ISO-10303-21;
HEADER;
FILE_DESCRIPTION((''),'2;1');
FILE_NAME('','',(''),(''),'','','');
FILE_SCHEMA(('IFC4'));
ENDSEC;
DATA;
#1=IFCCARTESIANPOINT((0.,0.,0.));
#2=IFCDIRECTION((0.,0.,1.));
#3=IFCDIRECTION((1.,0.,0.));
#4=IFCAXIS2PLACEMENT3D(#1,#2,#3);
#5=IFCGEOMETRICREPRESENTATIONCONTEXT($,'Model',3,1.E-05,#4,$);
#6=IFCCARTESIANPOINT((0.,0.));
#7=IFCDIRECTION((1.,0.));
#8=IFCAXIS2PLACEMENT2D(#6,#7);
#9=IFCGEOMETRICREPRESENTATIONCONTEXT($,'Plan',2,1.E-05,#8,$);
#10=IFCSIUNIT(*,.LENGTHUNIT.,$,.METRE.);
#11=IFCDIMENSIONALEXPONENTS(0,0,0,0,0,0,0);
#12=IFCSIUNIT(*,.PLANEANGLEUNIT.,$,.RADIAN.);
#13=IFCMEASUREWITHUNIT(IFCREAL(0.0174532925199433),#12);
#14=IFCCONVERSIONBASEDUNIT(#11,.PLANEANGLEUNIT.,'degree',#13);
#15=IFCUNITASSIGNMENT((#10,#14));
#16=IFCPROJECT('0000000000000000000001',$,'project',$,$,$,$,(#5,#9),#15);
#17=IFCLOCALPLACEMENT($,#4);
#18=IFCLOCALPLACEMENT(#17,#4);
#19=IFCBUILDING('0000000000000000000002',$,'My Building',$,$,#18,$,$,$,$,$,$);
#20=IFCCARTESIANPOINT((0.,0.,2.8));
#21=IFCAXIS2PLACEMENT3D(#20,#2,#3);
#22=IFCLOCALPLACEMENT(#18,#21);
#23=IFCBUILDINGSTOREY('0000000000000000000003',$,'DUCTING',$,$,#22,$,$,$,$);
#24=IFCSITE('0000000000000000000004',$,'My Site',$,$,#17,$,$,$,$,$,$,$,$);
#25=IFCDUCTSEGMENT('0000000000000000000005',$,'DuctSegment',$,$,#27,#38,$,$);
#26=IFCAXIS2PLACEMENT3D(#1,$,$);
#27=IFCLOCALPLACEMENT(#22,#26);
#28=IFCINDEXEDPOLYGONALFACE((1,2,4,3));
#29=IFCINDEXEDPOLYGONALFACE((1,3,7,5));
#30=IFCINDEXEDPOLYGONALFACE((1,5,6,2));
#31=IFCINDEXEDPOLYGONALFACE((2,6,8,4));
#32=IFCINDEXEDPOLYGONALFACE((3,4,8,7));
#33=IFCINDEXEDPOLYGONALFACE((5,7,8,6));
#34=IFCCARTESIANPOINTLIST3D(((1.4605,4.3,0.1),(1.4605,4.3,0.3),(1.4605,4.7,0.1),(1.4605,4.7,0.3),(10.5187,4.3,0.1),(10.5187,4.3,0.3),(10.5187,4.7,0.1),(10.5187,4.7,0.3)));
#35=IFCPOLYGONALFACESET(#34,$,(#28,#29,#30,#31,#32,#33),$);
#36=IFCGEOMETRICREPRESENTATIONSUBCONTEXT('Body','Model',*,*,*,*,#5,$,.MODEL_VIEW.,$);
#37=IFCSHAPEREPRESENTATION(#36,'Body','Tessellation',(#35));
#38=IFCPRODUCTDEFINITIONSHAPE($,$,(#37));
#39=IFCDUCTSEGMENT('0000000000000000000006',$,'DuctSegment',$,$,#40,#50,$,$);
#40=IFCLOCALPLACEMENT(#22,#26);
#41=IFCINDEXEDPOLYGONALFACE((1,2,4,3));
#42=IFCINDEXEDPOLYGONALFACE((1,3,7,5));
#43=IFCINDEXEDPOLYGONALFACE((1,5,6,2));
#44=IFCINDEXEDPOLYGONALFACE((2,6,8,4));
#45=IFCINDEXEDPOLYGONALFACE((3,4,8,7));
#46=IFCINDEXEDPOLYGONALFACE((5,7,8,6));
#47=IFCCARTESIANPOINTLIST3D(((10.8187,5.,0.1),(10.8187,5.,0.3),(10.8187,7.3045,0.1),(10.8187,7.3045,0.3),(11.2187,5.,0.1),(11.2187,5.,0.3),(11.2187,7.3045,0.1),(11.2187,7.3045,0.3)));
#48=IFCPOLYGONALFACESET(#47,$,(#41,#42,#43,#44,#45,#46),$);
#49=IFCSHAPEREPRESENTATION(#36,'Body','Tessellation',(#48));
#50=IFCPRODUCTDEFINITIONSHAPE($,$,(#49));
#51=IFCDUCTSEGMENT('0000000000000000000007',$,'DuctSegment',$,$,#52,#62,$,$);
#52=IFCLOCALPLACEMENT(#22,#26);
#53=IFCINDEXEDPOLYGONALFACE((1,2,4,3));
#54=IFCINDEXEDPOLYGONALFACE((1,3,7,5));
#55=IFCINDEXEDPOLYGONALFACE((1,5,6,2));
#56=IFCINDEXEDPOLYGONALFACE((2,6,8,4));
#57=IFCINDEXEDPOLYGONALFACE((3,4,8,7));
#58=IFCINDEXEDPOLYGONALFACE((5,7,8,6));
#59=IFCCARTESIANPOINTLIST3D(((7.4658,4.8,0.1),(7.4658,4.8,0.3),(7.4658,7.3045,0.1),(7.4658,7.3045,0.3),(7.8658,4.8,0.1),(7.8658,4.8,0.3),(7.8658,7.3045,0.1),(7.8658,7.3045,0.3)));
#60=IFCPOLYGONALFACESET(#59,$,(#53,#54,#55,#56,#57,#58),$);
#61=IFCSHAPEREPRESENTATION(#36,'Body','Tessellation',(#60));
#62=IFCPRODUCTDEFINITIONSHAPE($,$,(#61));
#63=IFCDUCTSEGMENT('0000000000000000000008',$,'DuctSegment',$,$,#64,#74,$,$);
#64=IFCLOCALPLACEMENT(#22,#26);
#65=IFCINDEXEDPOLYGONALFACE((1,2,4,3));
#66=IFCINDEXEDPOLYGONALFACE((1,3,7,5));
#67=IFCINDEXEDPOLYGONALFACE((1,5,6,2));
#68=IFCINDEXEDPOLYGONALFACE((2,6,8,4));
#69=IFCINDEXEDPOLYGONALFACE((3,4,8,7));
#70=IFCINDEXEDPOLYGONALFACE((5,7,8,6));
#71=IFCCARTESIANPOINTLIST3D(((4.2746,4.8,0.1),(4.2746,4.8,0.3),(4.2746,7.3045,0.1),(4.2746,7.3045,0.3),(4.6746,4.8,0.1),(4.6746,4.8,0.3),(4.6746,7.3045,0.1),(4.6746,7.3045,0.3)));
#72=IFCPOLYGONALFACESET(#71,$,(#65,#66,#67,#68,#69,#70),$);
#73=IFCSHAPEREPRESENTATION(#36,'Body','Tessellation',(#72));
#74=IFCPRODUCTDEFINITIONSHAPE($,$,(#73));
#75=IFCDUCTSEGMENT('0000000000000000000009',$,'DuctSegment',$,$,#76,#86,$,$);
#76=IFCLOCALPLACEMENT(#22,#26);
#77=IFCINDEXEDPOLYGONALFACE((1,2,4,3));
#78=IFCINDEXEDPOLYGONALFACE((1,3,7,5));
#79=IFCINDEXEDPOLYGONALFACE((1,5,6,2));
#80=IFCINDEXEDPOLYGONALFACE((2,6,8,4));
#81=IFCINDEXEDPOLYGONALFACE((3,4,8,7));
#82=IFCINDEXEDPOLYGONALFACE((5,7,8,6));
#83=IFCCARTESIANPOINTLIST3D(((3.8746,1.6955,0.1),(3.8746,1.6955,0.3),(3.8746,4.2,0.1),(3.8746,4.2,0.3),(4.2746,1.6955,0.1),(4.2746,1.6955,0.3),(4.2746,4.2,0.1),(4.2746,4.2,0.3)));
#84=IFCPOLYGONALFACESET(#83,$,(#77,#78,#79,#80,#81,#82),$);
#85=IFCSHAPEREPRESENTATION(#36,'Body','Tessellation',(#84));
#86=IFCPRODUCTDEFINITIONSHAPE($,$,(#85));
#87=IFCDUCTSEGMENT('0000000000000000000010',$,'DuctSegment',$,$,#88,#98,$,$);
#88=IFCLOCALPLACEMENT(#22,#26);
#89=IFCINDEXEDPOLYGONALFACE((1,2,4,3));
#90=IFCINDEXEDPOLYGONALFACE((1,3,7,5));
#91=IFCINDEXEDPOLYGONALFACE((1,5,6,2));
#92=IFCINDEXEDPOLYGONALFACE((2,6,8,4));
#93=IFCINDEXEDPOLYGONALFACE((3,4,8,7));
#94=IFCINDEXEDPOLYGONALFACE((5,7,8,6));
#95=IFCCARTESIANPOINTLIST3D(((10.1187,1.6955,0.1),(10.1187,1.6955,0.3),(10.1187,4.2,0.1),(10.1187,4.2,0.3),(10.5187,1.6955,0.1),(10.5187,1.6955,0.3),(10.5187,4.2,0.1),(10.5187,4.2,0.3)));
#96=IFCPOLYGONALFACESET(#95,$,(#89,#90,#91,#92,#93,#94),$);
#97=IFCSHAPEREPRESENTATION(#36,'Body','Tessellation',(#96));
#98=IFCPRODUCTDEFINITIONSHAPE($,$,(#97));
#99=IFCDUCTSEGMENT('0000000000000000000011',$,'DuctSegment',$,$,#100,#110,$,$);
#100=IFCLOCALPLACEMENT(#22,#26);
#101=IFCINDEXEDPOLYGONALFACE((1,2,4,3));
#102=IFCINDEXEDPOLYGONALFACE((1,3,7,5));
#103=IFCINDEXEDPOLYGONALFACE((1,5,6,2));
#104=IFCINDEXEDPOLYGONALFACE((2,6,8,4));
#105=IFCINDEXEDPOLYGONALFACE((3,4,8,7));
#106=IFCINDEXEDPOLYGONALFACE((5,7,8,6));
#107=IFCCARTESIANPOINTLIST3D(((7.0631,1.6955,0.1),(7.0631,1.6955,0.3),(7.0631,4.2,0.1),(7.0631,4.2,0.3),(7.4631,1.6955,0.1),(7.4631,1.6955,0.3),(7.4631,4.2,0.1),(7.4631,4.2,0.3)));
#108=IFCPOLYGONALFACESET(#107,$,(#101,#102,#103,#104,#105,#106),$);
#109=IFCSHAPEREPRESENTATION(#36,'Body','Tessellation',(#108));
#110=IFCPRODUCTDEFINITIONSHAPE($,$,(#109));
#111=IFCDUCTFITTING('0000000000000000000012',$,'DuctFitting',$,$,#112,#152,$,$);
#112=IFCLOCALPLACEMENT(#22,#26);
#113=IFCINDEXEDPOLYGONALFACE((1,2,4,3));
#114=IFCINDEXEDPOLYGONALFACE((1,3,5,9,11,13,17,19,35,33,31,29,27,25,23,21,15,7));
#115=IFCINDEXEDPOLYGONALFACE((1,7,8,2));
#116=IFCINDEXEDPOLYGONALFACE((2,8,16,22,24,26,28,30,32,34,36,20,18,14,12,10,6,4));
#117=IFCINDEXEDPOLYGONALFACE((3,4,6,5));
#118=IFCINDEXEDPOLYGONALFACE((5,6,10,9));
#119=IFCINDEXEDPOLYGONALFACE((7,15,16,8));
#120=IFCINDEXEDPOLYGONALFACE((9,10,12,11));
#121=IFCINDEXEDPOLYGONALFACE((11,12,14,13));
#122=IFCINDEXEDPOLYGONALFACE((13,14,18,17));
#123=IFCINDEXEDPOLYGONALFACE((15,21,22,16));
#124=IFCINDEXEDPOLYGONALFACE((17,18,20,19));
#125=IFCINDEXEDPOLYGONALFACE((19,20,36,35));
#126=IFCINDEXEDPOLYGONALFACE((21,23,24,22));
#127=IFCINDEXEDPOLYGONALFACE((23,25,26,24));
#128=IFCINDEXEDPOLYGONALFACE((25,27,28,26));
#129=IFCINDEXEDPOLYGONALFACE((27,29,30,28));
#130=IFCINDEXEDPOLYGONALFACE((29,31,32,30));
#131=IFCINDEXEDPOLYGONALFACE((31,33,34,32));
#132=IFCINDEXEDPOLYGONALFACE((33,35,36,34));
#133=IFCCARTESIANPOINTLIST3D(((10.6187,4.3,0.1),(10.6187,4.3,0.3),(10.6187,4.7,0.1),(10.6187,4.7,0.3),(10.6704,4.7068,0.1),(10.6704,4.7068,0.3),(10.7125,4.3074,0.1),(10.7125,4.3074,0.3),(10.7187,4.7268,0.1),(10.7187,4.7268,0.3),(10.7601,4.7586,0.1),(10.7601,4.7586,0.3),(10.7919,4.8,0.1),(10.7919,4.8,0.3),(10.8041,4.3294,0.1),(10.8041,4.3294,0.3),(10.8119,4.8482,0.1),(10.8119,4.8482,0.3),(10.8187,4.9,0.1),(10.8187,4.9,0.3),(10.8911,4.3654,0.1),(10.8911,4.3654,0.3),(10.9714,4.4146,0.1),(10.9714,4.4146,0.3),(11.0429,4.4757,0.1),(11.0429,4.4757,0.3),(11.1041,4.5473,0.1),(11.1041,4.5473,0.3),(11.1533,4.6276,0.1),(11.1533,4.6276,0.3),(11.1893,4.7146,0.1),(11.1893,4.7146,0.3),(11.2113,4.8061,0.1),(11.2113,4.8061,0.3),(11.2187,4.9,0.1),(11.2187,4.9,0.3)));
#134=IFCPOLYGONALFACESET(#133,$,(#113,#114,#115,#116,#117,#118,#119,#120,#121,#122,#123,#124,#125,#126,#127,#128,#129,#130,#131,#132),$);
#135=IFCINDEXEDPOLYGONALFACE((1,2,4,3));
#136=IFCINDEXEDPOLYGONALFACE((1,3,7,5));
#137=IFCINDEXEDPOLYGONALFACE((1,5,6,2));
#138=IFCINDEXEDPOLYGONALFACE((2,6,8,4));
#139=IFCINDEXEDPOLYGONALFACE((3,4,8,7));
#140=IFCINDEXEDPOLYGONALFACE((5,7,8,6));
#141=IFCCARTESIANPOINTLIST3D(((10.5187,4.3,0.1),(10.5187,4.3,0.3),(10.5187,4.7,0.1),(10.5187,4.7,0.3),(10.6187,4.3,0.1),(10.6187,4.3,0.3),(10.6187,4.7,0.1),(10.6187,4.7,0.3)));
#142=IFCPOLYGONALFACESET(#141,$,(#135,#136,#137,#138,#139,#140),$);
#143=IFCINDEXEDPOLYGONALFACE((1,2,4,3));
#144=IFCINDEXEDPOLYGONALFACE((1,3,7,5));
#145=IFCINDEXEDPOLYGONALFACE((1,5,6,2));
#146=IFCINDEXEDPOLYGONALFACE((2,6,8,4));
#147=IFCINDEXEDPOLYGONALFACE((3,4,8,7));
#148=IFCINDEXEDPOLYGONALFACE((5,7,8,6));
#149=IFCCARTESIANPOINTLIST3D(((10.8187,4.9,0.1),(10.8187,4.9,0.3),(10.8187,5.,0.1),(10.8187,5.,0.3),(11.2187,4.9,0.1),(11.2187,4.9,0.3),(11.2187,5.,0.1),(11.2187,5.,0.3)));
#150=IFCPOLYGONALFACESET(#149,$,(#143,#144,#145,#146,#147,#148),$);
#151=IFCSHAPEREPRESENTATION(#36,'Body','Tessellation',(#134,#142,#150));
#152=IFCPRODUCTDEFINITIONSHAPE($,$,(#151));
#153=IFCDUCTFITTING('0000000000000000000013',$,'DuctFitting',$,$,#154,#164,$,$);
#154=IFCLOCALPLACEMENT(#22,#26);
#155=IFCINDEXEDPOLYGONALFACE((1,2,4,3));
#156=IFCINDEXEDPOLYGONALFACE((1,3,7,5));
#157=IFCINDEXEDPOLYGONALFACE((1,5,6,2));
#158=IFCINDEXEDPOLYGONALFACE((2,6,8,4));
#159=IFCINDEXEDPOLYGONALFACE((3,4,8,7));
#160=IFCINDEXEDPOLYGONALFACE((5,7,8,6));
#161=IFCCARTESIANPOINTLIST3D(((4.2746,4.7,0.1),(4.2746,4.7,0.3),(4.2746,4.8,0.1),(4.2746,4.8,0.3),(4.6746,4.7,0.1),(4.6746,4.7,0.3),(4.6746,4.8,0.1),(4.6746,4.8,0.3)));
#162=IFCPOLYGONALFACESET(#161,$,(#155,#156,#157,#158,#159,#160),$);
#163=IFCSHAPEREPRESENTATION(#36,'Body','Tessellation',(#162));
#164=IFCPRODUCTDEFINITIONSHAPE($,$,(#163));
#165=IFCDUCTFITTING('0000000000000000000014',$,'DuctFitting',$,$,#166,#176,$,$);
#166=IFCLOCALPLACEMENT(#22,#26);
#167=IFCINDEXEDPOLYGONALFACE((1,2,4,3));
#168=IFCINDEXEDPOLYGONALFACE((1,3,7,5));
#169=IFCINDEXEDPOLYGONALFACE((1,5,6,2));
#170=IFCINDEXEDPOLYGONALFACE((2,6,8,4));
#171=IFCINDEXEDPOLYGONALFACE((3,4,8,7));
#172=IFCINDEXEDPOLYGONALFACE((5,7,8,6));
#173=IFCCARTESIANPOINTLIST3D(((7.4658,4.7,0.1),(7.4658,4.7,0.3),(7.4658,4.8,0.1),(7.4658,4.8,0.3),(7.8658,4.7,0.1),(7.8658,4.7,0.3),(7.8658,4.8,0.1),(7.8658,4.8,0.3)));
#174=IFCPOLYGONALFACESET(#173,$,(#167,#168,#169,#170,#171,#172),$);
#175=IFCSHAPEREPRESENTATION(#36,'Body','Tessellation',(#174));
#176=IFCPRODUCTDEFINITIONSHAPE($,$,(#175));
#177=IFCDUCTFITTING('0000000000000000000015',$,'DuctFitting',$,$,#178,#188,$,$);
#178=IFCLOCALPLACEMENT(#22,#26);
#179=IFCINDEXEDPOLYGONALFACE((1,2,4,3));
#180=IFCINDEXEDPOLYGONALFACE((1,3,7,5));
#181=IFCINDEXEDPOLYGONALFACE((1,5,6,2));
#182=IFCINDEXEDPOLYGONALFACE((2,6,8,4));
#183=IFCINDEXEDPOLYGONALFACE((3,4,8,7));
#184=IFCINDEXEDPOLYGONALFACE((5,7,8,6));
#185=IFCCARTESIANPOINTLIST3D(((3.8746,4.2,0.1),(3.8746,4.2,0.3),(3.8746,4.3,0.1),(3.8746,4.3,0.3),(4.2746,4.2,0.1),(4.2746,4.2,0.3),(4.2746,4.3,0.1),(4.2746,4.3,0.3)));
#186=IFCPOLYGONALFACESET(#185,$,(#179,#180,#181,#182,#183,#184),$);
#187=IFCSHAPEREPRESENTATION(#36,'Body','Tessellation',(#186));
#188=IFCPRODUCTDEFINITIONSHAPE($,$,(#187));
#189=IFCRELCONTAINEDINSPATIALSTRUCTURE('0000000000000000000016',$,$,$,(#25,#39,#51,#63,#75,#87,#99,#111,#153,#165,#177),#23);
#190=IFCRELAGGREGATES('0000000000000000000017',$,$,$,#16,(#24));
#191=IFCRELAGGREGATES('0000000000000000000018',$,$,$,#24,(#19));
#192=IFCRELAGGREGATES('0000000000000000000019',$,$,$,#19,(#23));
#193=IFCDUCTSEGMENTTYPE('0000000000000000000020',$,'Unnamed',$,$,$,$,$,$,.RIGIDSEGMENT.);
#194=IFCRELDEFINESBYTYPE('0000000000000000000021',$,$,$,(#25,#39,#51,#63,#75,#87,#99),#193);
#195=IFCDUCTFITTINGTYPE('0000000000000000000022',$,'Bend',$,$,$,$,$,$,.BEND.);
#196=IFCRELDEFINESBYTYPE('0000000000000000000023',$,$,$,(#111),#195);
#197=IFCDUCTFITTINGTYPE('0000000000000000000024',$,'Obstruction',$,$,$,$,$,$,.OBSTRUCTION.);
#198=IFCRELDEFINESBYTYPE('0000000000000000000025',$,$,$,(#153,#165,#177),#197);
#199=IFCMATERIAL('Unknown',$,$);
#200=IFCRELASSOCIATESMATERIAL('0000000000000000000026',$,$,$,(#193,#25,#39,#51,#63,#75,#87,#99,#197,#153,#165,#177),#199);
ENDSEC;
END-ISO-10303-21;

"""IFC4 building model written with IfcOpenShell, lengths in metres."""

from ifc_helpers import new_model, entity, si_unit, converted_unit, frame, origin_with_axes, origin_2d_with_axis, place, context, subcontext, project, spatial, line, arc, indexed_curve, rectangle, outline, extrude, source, transform, mapped, material, material_profile, profile_set, profile_usage, type_object, type_shapes, element, save


model = new_model("IFC4")

# Units and contexts
model_context = context("Model", 3, precision=1e-05, world=origin_with_axes())
plan_context = context("Plan", 2, precision=1e-05, world=origin_2d_with_axis())
body_context = subcontext(model_context, "Body", "Model", "MODEL_VIEW")
ifc_project = project(units=[si_unit("LENGTHUNIT", "METRE"), converted_unit("PLANEANGLEUNIT", "degree", entity("IfcReal", 0.0174532925199433), si_unit("PLANEANGLEUNIT", "RADIAN"), dimensions=[0, 0, 0, 0, 0, 0, 0])], contexts=[model_context, plan_context])

# Site, building, storey
site_placement = place(None, origin_with_axes())
site = spatial("IfcSite", under=ifc_project, at=site_placement, Name="My Site")
building_placement = place(site_placement, origin_with_axes())
building = spatial("IfcBuilding", under=site, at=building_placement, Name="My Building")
storey_placement = place(building_placement, frame((0.0, 0.0, 2.8), z_axis=(0.0, 0.0, 1.0), x_axis=(1.0, 0.0, 0.0)))
storey = spatial("IfcBuildingStorey", under=building, at=storey_placement, Name="DUCTING")

# Duct segments
ifc_material = material(Name="Unknown")
ifc_material_profile_1 = material_profile(ifc_material, rectangle(XDim=0.4, YDim=0.2))
ifc_profile_set_1 = profile_set([ifc_material_profile_1])
ifc_profile_usage_1 = profile_usage(ifc_profile_set_1, cardinal=5)
duct_segment_type = type_object("IfcDuctSegmentType", Name="Unnamed", PredefinedType="RIGIDSEGMENT", material=ifc_profile_set_1)
duct_segment_1_placement = place(storey_placement, frame((1.4605, 4.5, 0.2), z_axis=(1.0, 0.0, 0.0), x_axis=(0.0, 1.0, 0.0)))
element("IfcDuctSegment", 1, at=duct_segment_1_placement, inside=storey, type_object=duct_segment_type, material=ifc_profile_usage_1, Name="DuctSegment", context=body_context, shape_type="SweptSolid", body=[
    extrude(rectangle(XDim=0.4, YDim=0.2), origin_with_axes(), (0.0, 0.0, 1.0), 9.0582),
])
ifc_profile_usage_2 = profile_usage(ifc_profile_set_1, cardinal=5)
duct_segment_2_placement = place(storey_placement, frame((11.0187, 5.0, 0.2), z_axis=(0.0, 1.0, 0.0), x_axis=(-1.0, 0.0, 0.0)))
element("IfcDuctSegment", 2, at=duct_segment_2_placement, inside=storey, type_object=duct_segment_type, material=ifc_profile_usage_2, Name="DuctSegment", context=body_context, shape_type="SweptSolid", body=[
    extrude(rectangle(XDim=0.4, YDim=0.2), origin_with_axes(), (0.0, 0.0, 1.0), 2.3045),
])
ifc_profile_usage_3 = profile_usage(ifc_profile_set_1, cardinal=5)
duct_segment_3_placement = place(storey_placement, frame((7.6658, 4.8, 0.2), z_axis=(0.0, 1.0, 0.0), x_axis=(-1.0, 0.0, 0.0)))
element("IfcDuctSegment", 3, at=duct_segment_3_placement, inside=storey, type_object=duct_segment_type, material=ifc_profile_usage_3, Name="DuctSegment", context=body_context, shape_type="SweptSolid", body=[
    extrude(rectangle(XDim=0.4, YDim=0.2), origin_with_axes(), (0.0, 0.0, 1.0), 2.5045),
])
ifc_profile_usage_4 = profile_usage(ifc_profile_set_1, cardinal=5)
duct_segment_4_placement = place(storey_placement, frame((4.4746, 4.8, 0.2), z_axis=(0.0, 1.0, 0.0), x_axis=(-1.0, 0.0, 0.0)))
element("IfcDuctSegment", 4, at=duct_segment_4_placement, inside=storey, type_object=duct_segment_type, material=ifc_profile_usage_4, Name="DuctSegment", context=body_context, shape_type="SweptSolid", body=[
    extrude(rectangle(XDim=0.4, YDim=0.2), origin_with_axes(), (0.0, 0.0, 1.0), 2.5045),
])
ifc_profile_usage_5 = profile_usage(ifc_profile_set_1, cardinal=5)
duct_segment_5_placement = place(storey_placement, frame((4.0746, 4.2, 0.2), z_axis=(0.0, -1.0, 0.0), x_axis=(1.0, 0.0, 0.0)))
element("IfcDuctSegment", 5, at=duct_segment_5_placement, inside=storey, type_object=duct_segment_type, material=ifc_profile_usage_5, Name="DuctSegment", context=body_context, shape_type="SweptSolid", body=[
    extrude(rectangle(XDim=0.4, YDim=0.2), origin_with_axes(), (0.0, 0.0, 1.0), 2.5045),
])
ifc_profile_usage_6 = profile_usage(ifc_profile_set_1, cardinal=5)
duct_segment_6_placement = place(storey_placement, frame((10.3187, 4.2, 0.2), z_axis=(0.0, -1.0, 0.0), x_axis=(1.0, 0.0, 0.0)))
element("IfcDuctSegment", 6, at=duct_segment_6_placement, inside=storey, type_object=duct_segment_type, material=ifc_profile_usage_6, Name="DuctSegment", context=body_context, shape_type="SweptSolid", body=[
    extrude(rectangle(XDim=0.4, YDim=0.2), origin_with_axes(), (0.0, 0.0, 1.0), 2.5045),
])
ifc_profile_usage_7 = profile_usage(ifc_profile_set_1, cardinal=5)
duct_segment_7_placement = place(storey_placement, frame((7.2631, 4.2, 0.2), z_axis=(0.0, -1.0, 0.0), x_axis=(1.0, 0.0, 0.0)))
element("IfcDuctSegment", 7, at=duct_segment_7_placement, inside=storey, type_object=duct_segment_type, material=ifc_profile_usage_7, Name="DuctSegment", context=body_context, shape_type="SweptSolid", body=[
    extrude(rectangle(XDim=0.4, YDim=0.2), origin_with_axes(), (0.0, 0.0, 1.0), 2.5045),
])

# Duct fittings
duct_fitting_type_1 = type_object("IfcDuctFittingType", Name="Bend", PredefinedType="BEND")
shared_shape = source(origin_with_axes(), body_context, "Body", "SweptSolid", [
    extrude(outline(indexed_curve([(0.2, 0.0), (0.2586, 0.1414), (0.4, 0.2), (0.4, 0.6), (-0.0243, 0.4243), (-0.2, 0.0)], segments=[arc(1, 2, 3), line(3, 4), arc(4, 5, 6), line(6, 1)])), frame((0.0, -0.1, 0.1), z_axis=(0.0, -1.0, 0.0), x_axis=(1.0, 0.0, 0.0)), (0.0, 0.0, -1.0), 0.2),
    extrude(rectangle(XDim=0.4, YDim=0.2), origin_with_axes(), (0.0, 0.0, 1.0), 0.1),
    extrude(rectangle(XDim=0.4, YDim=0.2), frame((0.4, 0.0, 0.5), z_axis=(1.0, 0.0, 0.0), x_axis=(0.0, 0.0, 1.0)), (0.0, 0.0, 1.0), 0.1),
])
type_shapes(duct_fitting_type_1, [shared_shape])
duct_fitting_1_placement = place(storey_placement, frame((10.5187, 4.5, 0.2), z_axis=(1.0, 0.0, 0.0), x_axis=(0.0, 1.0, 0.0)))
element("IfcDuctFitting", 8, at=duct_fitting_1_placement, inside=storey, type_object=duct_fitting_type_1, Name="DuctFitting", context=body_context, shape_type="MappedRepresentation", body=[
    mapped(shared_shape, transform((0.0, 0.0, 0.0), x_axis=(1.0, 0.0, 0.0), y_axis=(0.0, 1.0, 0.0), z_axis=(0.0, 0.0, 1.0), scale=1.0)),
])
ifc_material_profile_2 = material_profile(ifc_material, rectangle(XDim=0.4, YDim=0.2))
ifc_profile_set_2 = profile_set([ifc_material_profile_2])
ifc_profile_usage_8 = profile_usage(ifc_profile_set_2, cardinal=5)
duct_fitting_type_2 = type_object("IfcDuctFittingType", Name="Obstruction", PredefinedType="OBSTRUCTION", material=ifc_profile_set_2)
duct_fitting_2_placement = place(storey_placement, frame((4.4746, 4.7, 0.2), z_axis=(0.0, 1.0, 0.0), x_axis=(-1.0, 0.0, 0.0)))
element("IfcDuctFitting", 9, at=duct_fitting_2_placement, inside=storey, type_object=duct_fitting_type_2, material=ifc_profile_usage_8, Name="DuctFitting", context=body_context, shape_type="SweptSolid", body=[
    extrude(rectangle(XDim=0.4, YDim=0.2), origin_with_axes(), (0.0, 0.0, 1.0), 0.1),
])
ifc_profile_usage_9 = profile_usage(ifc_profile_set_2, cardinal=5)
duct_fitting_3_placement = place(storey_placement, frame((7.6658, 4.7, 0.2), z_axis=(0.0, 1.0, 0.0), x_axis=(-1.0, 0.0, 0.0)))
element("IfcDuctFitting", 10, at=duct_fitting_3_placement, inside=storey, type_object=duct_fitting_type_2, material=ifc_profile_usage_9, Name="DuctFitting", context=body_context, shape_type="SweptSolid", body=[
    extrude(rectangle(XDim=0.4, YDim=0.2), origin_with_axes(), (0.0, 0.0, 1.0), 0.1),
])
ifc_profile_usage_10 = profile_usage(ifc_profile_set_2, cardinal=5)
duct_fitting_4_placement = place(storey_placement, frame((4.0746, 4.3, 0.2), z_axis=(0.0, -1.0, 0.0), x_axis=(1.0, 0.0, 0.0)))
element("IfcDuctFitting", 11, at=duct_fitting_4_placement, inside=storey, type_object=duct_fitting_type_2, material=ifc_profile_usage_10, Name="DuctFitting", context=body_context, shape_type="SweptSolid", body=[
    extrude(rectangle(XDim=0.4, YDim=0.2), origin_with_axes(), (0.0, 0.0, 1.0), 0.1),
])

save(model, "model.ifc")
